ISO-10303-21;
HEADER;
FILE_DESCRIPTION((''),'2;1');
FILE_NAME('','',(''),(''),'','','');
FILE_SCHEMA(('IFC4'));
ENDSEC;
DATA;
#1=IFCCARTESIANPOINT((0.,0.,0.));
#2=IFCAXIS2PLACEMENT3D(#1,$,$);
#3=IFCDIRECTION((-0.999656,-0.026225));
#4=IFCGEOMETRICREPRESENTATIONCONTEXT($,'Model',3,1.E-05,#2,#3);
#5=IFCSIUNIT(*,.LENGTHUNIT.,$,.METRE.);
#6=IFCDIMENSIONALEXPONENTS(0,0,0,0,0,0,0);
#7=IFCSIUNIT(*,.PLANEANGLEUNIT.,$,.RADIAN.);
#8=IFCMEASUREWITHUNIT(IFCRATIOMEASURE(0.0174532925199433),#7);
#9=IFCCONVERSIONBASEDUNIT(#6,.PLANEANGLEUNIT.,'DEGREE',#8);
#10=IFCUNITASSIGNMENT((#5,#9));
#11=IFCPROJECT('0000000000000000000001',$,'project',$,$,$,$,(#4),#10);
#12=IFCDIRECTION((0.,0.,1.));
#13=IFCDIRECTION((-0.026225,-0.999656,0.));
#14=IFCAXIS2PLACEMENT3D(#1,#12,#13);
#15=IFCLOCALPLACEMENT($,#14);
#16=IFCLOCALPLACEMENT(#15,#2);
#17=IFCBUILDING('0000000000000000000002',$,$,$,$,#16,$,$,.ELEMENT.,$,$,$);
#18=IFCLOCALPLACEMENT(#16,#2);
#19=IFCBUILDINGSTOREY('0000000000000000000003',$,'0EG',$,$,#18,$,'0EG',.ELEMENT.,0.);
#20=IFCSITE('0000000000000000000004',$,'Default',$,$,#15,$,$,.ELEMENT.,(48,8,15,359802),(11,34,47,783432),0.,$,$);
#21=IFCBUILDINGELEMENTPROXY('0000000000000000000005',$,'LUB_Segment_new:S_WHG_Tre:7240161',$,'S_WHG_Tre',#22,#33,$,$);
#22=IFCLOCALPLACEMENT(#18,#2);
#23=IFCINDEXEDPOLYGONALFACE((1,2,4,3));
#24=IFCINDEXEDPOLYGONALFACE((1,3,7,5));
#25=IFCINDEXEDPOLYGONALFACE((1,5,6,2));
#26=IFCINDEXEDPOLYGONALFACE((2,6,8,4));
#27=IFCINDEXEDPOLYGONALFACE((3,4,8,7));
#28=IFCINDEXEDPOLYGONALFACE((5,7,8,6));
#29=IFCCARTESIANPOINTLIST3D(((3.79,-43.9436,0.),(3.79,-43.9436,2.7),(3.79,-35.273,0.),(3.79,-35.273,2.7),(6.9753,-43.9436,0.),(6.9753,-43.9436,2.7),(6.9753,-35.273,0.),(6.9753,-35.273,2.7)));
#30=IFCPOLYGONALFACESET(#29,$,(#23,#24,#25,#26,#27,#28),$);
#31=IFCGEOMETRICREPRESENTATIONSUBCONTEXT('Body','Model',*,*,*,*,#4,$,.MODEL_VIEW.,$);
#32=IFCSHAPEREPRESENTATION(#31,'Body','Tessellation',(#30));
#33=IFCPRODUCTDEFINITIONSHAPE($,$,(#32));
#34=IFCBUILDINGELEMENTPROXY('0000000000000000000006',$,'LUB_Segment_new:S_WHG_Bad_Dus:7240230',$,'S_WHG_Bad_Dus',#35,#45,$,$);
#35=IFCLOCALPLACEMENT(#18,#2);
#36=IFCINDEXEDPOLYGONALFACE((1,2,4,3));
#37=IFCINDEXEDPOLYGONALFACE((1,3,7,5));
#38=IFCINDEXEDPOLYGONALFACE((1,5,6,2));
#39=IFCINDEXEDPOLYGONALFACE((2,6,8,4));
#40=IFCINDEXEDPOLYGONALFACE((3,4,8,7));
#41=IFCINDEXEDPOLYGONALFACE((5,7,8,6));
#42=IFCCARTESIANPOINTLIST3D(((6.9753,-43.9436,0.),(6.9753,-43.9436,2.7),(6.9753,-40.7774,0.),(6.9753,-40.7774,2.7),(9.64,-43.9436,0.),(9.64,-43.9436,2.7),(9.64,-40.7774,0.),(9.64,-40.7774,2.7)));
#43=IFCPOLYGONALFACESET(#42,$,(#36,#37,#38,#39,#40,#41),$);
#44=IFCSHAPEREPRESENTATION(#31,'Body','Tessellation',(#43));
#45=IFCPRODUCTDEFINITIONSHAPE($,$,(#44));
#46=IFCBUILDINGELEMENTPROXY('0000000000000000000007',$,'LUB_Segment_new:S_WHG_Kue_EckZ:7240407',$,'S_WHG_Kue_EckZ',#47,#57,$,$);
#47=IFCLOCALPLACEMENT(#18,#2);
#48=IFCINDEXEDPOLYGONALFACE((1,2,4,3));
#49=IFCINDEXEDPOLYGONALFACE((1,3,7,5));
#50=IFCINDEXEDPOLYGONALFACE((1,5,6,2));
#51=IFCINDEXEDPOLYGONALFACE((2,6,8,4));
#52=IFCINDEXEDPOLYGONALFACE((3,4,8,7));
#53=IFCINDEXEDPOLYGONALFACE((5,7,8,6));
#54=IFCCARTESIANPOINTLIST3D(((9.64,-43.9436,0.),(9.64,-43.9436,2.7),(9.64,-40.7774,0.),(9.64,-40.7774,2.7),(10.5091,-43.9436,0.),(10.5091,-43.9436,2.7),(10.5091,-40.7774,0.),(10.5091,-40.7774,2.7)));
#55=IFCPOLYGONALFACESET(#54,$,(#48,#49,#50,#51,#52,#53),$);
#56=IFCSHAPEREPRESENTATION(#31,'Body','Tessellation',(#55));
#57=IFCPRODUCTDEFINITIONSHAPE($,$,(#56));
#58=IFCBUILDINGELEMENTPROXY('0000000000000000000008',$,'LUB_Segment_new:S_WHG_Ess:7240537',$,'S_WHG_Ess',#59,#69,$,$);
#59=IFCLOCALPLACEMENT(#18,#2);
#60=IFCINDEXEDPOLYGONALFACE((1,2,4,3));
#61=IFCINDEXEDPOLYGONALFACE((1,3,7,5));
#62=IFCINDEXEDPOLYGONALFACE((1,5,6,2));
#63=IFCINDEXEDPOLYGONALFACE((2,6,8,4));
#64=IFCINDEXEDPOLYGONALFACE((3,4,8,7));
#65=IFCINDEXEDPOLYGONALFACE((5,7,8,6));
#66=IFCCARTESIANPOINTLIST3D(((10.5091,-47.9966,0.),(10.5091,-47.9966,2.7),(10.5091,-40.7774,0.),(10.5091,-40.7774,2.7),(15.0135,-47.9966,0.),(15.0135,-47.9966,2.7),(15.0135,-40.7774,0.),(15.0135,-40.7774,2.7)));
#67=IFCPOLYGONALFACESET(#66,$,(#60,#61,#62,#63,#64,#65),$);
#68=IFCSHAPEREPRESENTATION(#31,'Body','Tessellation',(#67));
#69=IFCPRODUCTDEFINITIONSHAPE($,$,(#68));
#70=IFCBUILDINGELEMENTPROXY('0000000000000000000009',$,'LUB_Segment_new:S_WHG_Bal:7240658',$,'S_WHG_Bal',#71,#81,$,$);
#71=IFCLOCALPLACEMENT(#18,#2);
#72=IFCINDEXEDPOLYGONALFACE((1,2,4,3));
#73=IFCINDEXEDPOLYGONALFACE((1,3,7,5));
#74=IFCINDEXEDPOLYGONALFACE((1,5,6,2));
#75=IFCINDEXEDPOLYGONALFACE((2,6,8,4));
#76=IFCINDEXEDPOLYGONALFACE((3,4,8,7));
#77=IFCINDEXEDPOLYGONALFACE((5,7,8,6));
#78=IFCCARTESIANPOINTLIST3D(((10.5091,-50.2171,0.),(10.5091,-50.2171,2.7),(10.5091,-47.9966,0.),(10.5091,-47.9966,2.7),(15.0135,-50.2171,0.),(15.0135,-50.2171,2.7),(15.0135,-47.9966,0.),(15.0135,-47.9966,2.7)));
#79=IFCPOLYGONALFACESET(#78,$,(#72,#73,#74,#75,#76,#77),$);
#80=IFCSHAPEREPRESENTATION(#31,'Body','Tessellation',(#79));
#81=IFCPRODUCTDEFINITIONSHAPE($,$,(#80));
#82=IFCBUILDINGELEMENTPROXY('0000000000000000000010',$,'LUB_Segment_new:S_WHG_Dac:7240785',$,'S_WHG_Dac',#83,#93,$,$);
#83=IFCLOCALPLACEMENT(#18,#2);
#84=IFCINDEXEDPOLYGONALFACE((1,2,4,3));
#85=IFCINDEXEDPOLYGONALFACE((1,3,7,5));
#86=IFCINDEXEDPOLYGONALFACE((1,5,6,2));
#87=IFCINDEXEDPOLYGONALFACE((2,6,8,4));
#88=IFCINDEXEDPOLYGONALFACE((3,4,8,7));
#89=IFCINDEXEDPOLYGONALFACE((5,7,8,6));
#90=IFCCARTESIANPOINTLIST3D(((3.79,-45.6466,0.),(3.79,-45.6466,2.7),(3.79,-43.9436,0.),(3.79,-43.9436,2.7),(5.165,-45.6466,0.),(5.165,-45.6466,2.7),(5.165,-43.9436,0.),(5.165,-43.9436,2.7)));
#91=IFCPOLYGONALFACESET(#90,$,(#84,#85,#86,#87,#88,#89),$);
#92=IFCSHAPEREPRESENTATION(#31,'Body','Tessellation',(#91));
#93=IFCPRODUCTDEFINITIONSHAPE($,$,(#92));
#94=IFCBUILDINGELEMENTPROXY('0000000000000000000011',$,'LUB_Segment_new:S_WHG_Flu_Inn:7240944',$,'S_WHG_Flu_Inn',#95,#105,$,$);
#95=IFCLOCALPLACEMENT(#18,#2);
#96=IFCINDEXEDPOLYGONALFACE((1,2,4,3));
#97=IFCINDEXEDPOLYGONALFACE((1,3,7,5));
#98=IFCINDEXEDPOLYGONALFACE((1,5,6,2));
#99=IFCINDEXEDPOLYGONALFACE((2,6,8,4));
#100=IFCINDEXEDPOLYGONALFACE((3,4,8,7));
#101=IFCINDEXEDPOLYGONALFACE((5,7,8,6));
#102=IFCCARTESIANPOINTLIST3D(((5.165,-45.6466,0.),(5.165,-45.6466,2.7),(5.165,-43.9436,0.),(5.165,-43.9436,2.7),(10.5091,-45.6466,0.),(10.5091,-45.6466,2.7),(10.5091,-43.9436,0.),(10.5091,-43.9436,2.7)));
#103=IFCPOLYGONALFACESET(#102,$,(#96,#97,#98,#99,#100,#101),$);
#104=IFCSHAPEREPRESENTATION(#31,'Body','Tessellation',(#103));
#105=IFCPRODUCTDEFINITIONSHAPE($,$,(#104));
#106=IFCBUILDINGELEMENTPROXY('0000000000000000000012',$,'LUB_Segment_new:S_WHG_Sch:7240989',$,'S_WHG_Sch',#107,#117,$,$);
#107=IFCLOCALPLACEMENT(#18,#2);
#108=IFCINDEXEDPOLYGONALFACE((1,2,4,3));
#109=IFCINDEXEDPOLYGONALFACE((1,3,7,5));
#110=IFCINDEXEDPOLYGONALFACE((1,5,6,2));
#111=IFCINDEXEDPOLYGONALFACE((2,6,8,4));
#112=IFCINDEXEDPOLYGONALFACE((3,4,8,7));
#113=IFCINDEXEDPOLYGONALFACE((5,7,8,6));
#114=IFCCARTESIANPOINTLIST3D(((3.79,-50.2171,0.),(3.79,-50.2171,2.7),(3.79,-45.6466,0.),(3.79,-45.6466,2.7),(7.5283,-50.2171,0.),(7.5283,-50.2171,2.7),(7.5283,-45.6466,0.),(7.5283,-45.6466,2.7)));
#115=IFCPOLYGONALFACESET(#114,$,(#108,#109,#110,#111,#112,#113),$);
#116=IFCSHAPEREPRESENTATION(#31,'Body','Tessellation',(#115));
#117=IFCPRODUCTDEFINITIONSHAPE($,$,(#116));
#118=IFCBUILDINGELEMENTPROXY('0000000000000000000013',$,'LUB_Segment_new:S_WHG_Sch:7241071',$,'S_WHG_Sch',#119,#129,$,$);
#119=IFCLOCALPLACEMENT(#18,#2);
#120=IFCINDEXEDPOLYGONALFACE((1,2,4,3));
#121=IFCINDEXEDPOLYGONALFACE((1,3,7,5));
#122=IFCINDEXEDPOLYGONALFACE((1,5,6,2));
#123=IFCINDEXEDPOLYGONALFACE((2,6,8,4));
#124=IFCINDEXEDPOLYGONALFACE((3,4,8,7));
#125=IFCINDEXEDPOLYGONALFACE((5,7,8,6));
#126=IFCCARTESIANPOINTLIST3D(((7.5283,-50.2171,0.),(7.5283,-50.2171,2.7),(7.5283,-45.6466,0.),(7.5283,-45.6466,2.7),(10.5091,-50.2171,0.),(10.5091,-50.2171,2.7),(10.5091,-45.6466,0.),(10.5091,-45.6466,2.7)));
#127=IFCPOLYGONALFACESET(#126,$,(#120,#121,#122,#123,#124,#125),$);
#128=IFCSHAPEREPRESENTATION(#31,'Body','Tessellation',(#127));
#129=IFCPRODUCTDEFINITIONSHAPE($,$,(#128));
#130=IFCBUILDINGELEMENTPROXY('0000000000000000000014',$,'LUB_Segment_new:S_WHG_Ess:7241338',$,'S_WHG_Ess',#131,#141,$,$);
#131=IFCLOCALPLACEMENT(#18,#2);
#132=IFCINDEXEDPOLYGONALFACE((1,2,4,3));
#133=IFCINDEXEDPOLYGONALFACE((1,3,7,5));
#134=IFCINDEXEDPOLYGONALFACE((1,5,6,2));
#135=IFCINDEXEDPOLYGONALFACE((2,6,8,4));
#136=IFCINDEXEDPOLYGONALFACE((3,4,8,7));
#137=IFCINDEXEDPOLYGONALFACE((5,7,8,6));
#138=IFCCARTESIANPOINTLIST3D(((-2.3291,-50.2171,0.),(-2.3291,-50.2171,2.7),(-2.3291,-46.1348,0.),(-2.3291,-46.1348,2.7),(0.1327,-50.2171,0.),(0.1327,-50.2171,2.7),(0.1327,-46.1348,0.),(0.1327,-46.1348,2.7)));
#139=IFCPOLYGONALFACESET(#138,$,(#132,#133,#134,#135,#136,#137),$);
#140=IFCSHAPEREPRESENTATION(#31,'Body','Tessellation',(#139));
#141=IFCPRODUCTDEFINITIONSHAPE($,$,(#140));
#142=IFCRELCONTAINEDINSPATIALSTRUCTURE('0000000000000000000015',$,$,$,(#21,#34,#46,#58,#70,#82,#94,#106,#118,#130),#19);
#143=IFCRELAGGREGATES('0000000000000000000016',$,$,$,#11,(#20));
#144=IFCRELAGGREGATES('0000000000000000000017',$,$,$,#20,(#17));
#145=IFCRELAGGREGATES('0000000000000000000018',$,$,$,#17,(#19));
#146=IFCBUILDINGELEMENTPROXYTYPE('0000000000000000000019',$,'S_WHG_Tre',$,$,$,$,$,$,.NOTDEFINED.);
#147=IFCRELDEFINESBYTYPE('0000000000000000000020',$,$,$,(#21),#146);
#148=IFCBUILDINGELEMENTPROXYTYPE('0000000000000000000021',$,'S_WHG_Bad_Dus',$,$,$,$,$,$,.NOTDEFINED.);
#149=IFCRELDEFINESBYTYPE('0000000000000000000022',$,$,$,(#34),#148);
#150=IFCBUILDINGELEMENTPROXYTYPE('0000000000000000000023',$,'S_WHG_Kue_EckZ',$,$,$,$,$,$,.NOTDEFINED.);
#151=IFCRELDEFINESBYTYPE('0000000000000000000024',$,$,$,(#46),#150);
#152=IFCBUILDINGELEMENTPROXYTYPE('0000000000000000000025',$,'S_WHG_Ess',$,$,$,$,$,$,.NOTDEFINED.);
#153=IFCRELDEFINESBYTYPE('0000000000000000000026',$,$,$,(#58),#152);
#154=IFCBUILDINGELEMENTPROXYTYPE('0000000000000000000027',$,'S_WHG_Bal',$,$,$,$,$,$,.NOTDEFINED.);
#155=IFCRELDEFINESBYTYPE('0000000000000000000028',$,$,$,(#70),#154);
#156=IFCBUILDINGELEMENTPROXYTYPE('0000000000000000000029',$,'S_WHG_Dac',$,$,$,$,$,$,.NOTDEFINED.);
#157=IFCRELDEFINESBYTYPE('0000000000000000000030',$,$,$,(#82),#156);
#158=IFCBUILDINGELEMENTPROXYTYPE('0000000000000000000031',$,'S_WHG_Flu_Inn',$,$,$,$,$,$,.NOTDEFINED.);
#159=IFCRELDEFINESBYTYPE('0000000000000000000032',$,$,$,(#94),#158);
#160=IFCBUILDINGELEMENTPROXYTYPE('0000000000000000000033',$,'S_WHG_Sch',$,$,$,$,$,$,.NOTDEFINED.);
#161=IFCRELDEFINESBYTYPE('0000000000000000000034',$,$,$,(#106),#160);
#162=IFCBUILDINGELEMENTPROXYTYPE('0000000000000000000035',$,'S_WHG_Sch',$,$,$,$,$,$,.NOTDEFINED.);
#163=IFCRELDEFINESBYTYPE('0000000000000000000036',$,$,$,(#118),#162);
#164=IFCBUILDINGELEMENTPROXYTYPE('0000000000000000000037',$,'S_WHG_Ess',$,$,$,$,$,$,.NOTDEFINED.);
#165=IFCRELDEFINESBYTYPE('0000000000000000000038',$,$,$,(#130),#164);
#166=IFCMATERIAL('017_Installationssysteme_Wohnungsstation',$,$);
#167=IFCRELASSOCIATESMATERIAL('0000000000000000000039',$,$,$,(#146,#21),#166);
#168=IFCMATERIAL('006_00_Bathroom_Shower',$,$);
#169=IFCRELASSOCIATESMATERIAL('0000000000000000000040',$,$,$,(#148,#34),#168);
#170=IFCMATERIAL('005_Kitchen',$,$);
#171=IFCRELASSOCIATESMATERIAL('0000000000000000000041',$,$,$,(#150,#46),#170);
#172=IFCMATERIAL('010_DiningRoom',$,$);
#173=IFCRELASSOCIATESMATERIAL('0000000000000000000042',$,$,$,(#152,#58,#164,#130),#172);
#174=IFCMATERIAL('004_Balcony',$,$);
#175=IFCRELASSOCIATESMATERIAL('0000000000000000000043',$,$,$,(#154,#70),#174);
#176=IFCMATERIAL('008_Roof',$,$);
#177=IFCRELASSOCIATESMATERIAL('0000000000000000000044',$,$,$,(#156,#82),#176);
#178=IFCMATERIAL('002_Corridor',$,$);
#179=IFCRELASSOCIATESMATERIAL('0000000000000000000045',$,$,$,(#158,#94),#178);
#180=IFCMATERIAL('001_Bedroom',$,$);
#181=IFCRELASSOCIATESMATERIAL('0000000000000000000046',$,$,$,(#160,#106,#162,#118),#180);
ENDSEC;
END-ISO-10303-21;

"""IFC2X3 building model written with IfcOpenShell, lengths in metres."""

from ifc_helpers import new_model, entity, si_unit, converted_unit, direction, frame, frame_2d, origin, origin_2d_with_axis, place, context, subcontext, project, spatial, rectangle, extrude, source, transform, mapped, material, type_object, type_shapes, element, save


model = new_model("IFC2X3")

# Units and contexts
model_context = context("Model", 3, precision=1e-05, world=origin(), true_north=direction((-0.999656, -0.026225)))
body_context = subcontext(model_context, "Body", "Model", "MODEL_VIEW")
ifc_project = project(units=[si_unit("LENGTHUNIT", "METRE"), converted_unit("PLANEANGLEUNIT", "DEGREE", entity("IfcRatioMeasure", 0.0174532925199433), si_unit("PLANEANGLEUNIT", "RADIAN"), dimensions=[0, 0, 0, 0, 0, 0, 0])], contexts=[model_context])

# Site, building, storey
site_placement = place(None, frame((0.0, 0.0, 0.0), z_axis=(0.0, 0.0, 1.0), x_axis=(-0.026225, -0.999656, 0.0)))
site = spatial("IfcSite", under=ifc_project, at=site_placement, Name="Default", CompositionType="ELEMENT", RefLatitude=(48, 8, 15, 359802), RefLongitude=(11, 34, 47, 783432), RefElevation=0.0)
building_placement = place(site_placement, origin())
building = spatial("IfcBuilding", under=site, at=building_placement, CompositionType="ELEMENT")
storey_placement = place(building_placement, origin())
storey = spatial("IfcBuildingStorey", under=building, at=storey_placement, Name="0EG", LongName="0EG", CompositionType="ELEMENT", Elevation=0.0)

# Building element proxies
ifc_material_1 = material(Name="001_Bedroom")
ifc_material_2 = material(Name="010_DiningRoom")
ifc_material_3 = material(Name="004_Balcony")
ifc_material_4 = material(Name="005_Kitchen")
ifc_material_5 = material(Name="002_Corridor")
ifc_material_6 = material(Name="008_Roof")
ifc_material_7 = material(Name="006_00_Bathroom_Shower")
ifc_material_8 = material(Name="017_Installationssysteme_Wohnungsstation")
building_element_proxy_type_1 = type_object("IfcBuildingElementProxyType", Name="S_WHG_Tre", PredefinedType="NOTDEFINED", material=ifc_material_8)
shared_shape_1 = source(origin(), body_context, "Body", "SweptSolid", [
    extrude(rectangle(XDim=3.1853, YDim=8.6706, at=frame_2d((0.0, 0.0), x_axis=(1.0, 0.0))), frame((0.0, 0.0, 0.0), z_axis=(0.0, 0.0, 1.0), x_axis=(-1.0, 0.0, 0.0)), (0.0, 0.0, 1.0), 2.7),
])
type_shapes(building_element_proxy_type_1, [shared_shape_1])
proxy_1_placement = place(storey_placement, frame((5.3827, -39.6083, 0.0)))
element("IfcBuildingElementProxy", 1, at=proxy_1_placement, inside=storey, type_object=building_element_proxy_type_1, material=ifc_material_8, Name="LUB_Segment_new:S_WHG_Tre:7240161", ObjectType="S_WHG_Tre", context=body_context, shape_type="MappedRepresentation", body=[
    mapped(shared_shape_1, transform((0.0, 0.0, 0.0), scale=1.0)),
])
building_element_proxy_type_2 = type_object("IfcBuildingElementProxyType", Name="S_WHG_Bad_Dus", PredefinedType="NOTDEFINED", material=ifc_material_7)
shared_shape_2 = source(origin(), body_context, "Body", "SweptSolid", [
    extrude(rectangle(XDim=3.1662, YDim=2.6647, at=origin_2d_with_axis()), frame((0.0, 0.0, 0.0), z_axis=(0.0, 0.0, 1.0), x_axis=(0.0, 1.0, 0.0)), (0.0, 0.0, 1.0), 2.7),
])
type_shapes(building_element_proxy_type_2, [shared_shape_2])
proxy_2_placement = place(storey_placement, frame((8.3077, -42.3605, 0.0)))
element("IfcBuildingElementProxy", 2, at=proxy_2_placement, inside=storey, type_object=building_element_proxy_type_2, material=ifc_material_7, Name="LUB_Segment_new:S_WHG_Bad_Dus:7240230", ObjectType="S_WHG_Bad_Dus", context=body_context, shape_type="MappedRepresentation", body=[
    mapped(shared_shape_2, transform((0.0, 0.0, 0.0), scale=1.0)),
])
building_element_proxy_type_3 = type_object("IfcBuildingElementProxyType", Name="S_WHG_Kue_EckZ", PredefinedType="NOTDEFINED", material=ifc_material_4)
shared_shape_3 = source(origin(), body_context, "Body", "SweptSolid", [
    extrude(rectangle(XDim=3.1662, YDim=0.8691, at=origin_2d_with_axis()), frame((0.0, 0.0, 0.0), z_axis=(0.0, 0.0, 1.0), x_axis=(0.0, 1.0, 0.0)), (0.0, 0.0, 1.0), 2.7),
])
type_shapes(building_element_proxy_type_3, [shared_shape_3])
proxy_3_placement = place(storey_placement, frame((10.0746, -42.3605, 0.0)))
element("IfcBuildingElementProxy", 3, at=proxy_3_placement, inside=storey, type_object=building_element_proxy_type_3, material=ifc_material_4, Name="LUB_Segment_new:S_WHG_Kue_EckZ:7240407", ObjectType="S_WHG_Kue_EckZ", context=body_context, shape_type="MappedRepresentation", body=[
    mapped(shared_shape_3, transform((0.0, 0.0, 0.0), scale=1.0)),
])
building_element_proxy_type_4 = type_object("IfcBuildingElementProxyType", Name="S_WHG_Ess", PredefinedType="NOTDEFINED", material=ifc_material_2)
shared_shape_4 = source(origin(), body_context, "Body", "SweptSolid", [
    extrude(rectangle(XDim=4.5044, YDim=7.2191, at=origin_2d_with_axis()), frame((0.0, 0.0, 0.0), z_axis=(0.0, 0.0, 1.0), x_axis=(-1.0, 0.0, 0.0)), (0.0, 0.0, 1.0), 2.7),
])
type_shapes(building_element_proxy_type_4, [shared_shape_4])
proxy_4_placement = place(storey_placement, frame((12.7613, -44.387, 0.0)))
element("IfcBuildingElementProxy", 4, at=proxy_4_placement, inside=storey, type_object=building_element_proxy_type_4, material=ifc_material_2, Name="LUB_Segment_new:S_WHG_Ess:7240537", ObjectType="S_WHG_Ess", context=body_context, shape_type="MappedRepresentation", body=[
    mapped(shared_shape_4, transform((0.0, 0.0, 0.0), scale=1.0)),
])
building_element_proxy_type_5 = type_object("IfcBuildingElementProxyType", Name="S_WHG_Bal", PredefinedType="NOTDEFINED", material=ifc_material_3)
shared_shape_5 = source(origin(), body_context, "Body", "SweptSolid", [
    extrude(rectangle(XDim=2.2206, YDim=4.5044, at=origin_2d_with_axis()), frame((0.0, 0.0, 0.0), z_axis=(0.0, 0.0, 1.0), x_axis=(0.0, 1.0, 0.0)), (0.0, 0.0, 1.0), 2.7),
])
type_shapes(building_element_proxy_type_5, [shared_shape_5])
proxy_5_placement = place(storey_placement, frame((12.7613, -49.1068, 0.0)))
element("IfcBuildingElementProxy", 5, at=proxy_5_placement, inside=storey, type_object=building_element_proxy_type_5, material=ifc_material_3, Name="LUB_Segment_new:S_WHG_Bal:7240658", ObjectType="S_WHG_Bal", context=body_context, shape_type="MappedRepresentation", body=[
    mapped(shared_shape_5, transform((0.0, 0.0, 0.0), scale=1.0)),
])
building_element_proxy_type_6 = type_object("IfcBuildingElementProxyType", Name="S_WHG_Dac", PredefinedType="NOTDEFINED", material=ifc_material_6)
shared_shape_6 = source(origin(), body_context, "Body", "SweptSolid", [
    extrude(rectangle(XDim=1.7029, YDim=1.375, at=origin_2d_with_axis()), frame((0.0, 0.0, 0.0), z_axis=(0.0, 0.0, 1.0), x_axis=(0.0, 1.0, 0.0)), (0.0, 0.0, 1.0), 2.7),
])
type_shapes(building_element_proxy_type_6, [shared_shape_6])
proxy_6_placement = place(storey_placement, frame((4.4775, -44.7951, 0.0)))
element("IfcBuildingElementProxy", 6, at=proxy_6_placement, inside=storey, type_object=building_element_proxy_type_6, material=ifc_material_6, Name="LUB_Segment_new:S_WHG_Dac:7240785", ObjectType="S_WHG_Dac", context=body_context, shape_type="MappedRepresentation", body=[
    mapped(shared_shape_6, transform((0.0, 0.0, 0.0), scale=1.0)),
])
building_element_proxy_type_7 = type_object("IfcBuildingElementProxyType", Name="S_WHG_Flu_Inn", PredefinedType="NOTDEFINED", material=ifc_material_5)
shared_shape_7 = source(origin(), body_context, "Body", "SweptSolid", [
    extrude(rectangle(XDim=1.7029, YDim=5.3441, at=origin_2d_with_axis()), frame((0.0, 0.0, 0.0), z_axis=(0.0, 0.0, 1.0), x_axis=(0.0, 1.0, 0.0)), (0.0, 0.0, 1.0), 2.7),
])
type_shapes(building_element_proxy_type_7, [shared_shape_7])
proxy_7_placement = place(storey_placement, frame((7.8371, -44.7951, 0.0)))
element("IfcBuildingElementProxy", 7, at=proxy_7_placement, inside=storey, type_object=building_element_proxy_type_7, material=ifc_material_5, Name="LUB_Segment_new:S_WHG_Flu_Inn:7240944", ObjectType="S_WHG_Flu_Inn", context=body_context, shape_type="MappedRepresentation", body=[
    mapped(shared_shape_7, transform((0.0, 0.0, 0.0), scale=1.0)),
])
building_element_proxy_type_8 = type_object("IfcBuildingElementProxyType", Name="S_WHG_Sch", PredefinedType="NOTDEFINED", material=ifc_material_1)
shared_shape_8 = source(origin(), body_context, "Body", "SweptSolid", [
    extrude(rectangle(XDim=3.7382, YDim=4.5706, at=origin_2d_with_axis()), frame((0.0, 0.0, 0.0), z_axis=(0.0, 0.0, 1.0), x_axis=(-1.0, 0.0, 0.0)), (0.0, 0.0, 1.0), 2.7),
])
type_shapes(building_element_proxy_type_8, [shared_shape_8])
proxy_8_placement = place(storey_placement, frame((5.6591, -47.9318, 0.0)))
element("IfcBuildingElementProxy", 8, at=proxy_8_placement, inside=storey, type_object=building_element_proxy_type_8, material=ifc_material_1, Name="LUB_Segment_new:S_WHG_Sch:7240989", ObjectType="S_WHG_Sch", context=body_context, shape_type="MappedRepresentation", body=[
    mapped(shared_shape_8, transform((0.0, 0.0, 0.0), scale=1.0)),
])
building_element_proxy_type_9 = type_object("IfcBuildingElementProxyType", Name="S_WHG_Sch", PredefinedType="NOTDEFINED", material=ifc_material_1)
shared_shape_9 = source(origin(), body_context, "Body", "SweptSolid", [
    extrude(rectangle(XDim=2.9809, YDim=4.5706, at=origin_2d_with_axis()), frame((0.0, 0.0, 0.0), z_axis=(0.0, 0.0, 1.0), x_axis=(-1.0, 0.0, 0.0)), (0.0, 0.0, 1.0), 2.7),
])
type_shapes(building_element_proxy_type_9, [shared_shape_9])
proxy_9_placement = place(storey_placement, frame((9.0187, -47.9318, 0.0)))
element("IfcBuildingElementProxy", 9, at=proxy_9_placement, inside=storey, type_object=building_element_proxy_type_9, material=ifc_material_1, Name="LUB_Segment_new:S_WHG_Sch:7241071", ObjectType="S_WHG_Sch", context=body_context, shape_type="MappedRepresentation", body=[
    mapped(shared_shape_9, transform((0.0, 0.0, 0.0), scale=1.0)),
])
building_element_proxy_type_10 = type_object("IfcBuildingElementProxyType", Name="S_WHG_Ess", PredefinedType="NOTDEFINED", material=ifc_material_2)
shared_shape_10 = source(origin(), body_context, "Body", "SweptSolid", [
    extrude(rectangle(XDim=4.0824, YDim=2.4618, at=origin_2d_with_axis()), frame((0.0, 0.0, 0.0), z_axis=(0.0, 0.0, 1.0), x_axis=(0.0, 1.0, 0.0)), (0.0, 0.0, 1.0), 2.7),
])
type_shapes(building_element_proxy_type_10, [shared_shape_10])
proxy_10_placement = place(storey_placement, frame((-1.0982, -48.176, 0.0)))
element("IfcBuildingElementProxy", 10, at=proxy_10_placement, inside=storey, type_object=building_element_proxy_type_10, material=ifc_material_2, Name="LUB_Segment_new:S_WHG_Ess:7241338", ObjectType="S_WHG_Ess", context=body_context, shape_type="MappedRepresentation", body=[
    mapped(shared_shape_10, transform((0.0, 0.0, 0.0), scale=1.0)),
])

save(model, "model.ifc")
